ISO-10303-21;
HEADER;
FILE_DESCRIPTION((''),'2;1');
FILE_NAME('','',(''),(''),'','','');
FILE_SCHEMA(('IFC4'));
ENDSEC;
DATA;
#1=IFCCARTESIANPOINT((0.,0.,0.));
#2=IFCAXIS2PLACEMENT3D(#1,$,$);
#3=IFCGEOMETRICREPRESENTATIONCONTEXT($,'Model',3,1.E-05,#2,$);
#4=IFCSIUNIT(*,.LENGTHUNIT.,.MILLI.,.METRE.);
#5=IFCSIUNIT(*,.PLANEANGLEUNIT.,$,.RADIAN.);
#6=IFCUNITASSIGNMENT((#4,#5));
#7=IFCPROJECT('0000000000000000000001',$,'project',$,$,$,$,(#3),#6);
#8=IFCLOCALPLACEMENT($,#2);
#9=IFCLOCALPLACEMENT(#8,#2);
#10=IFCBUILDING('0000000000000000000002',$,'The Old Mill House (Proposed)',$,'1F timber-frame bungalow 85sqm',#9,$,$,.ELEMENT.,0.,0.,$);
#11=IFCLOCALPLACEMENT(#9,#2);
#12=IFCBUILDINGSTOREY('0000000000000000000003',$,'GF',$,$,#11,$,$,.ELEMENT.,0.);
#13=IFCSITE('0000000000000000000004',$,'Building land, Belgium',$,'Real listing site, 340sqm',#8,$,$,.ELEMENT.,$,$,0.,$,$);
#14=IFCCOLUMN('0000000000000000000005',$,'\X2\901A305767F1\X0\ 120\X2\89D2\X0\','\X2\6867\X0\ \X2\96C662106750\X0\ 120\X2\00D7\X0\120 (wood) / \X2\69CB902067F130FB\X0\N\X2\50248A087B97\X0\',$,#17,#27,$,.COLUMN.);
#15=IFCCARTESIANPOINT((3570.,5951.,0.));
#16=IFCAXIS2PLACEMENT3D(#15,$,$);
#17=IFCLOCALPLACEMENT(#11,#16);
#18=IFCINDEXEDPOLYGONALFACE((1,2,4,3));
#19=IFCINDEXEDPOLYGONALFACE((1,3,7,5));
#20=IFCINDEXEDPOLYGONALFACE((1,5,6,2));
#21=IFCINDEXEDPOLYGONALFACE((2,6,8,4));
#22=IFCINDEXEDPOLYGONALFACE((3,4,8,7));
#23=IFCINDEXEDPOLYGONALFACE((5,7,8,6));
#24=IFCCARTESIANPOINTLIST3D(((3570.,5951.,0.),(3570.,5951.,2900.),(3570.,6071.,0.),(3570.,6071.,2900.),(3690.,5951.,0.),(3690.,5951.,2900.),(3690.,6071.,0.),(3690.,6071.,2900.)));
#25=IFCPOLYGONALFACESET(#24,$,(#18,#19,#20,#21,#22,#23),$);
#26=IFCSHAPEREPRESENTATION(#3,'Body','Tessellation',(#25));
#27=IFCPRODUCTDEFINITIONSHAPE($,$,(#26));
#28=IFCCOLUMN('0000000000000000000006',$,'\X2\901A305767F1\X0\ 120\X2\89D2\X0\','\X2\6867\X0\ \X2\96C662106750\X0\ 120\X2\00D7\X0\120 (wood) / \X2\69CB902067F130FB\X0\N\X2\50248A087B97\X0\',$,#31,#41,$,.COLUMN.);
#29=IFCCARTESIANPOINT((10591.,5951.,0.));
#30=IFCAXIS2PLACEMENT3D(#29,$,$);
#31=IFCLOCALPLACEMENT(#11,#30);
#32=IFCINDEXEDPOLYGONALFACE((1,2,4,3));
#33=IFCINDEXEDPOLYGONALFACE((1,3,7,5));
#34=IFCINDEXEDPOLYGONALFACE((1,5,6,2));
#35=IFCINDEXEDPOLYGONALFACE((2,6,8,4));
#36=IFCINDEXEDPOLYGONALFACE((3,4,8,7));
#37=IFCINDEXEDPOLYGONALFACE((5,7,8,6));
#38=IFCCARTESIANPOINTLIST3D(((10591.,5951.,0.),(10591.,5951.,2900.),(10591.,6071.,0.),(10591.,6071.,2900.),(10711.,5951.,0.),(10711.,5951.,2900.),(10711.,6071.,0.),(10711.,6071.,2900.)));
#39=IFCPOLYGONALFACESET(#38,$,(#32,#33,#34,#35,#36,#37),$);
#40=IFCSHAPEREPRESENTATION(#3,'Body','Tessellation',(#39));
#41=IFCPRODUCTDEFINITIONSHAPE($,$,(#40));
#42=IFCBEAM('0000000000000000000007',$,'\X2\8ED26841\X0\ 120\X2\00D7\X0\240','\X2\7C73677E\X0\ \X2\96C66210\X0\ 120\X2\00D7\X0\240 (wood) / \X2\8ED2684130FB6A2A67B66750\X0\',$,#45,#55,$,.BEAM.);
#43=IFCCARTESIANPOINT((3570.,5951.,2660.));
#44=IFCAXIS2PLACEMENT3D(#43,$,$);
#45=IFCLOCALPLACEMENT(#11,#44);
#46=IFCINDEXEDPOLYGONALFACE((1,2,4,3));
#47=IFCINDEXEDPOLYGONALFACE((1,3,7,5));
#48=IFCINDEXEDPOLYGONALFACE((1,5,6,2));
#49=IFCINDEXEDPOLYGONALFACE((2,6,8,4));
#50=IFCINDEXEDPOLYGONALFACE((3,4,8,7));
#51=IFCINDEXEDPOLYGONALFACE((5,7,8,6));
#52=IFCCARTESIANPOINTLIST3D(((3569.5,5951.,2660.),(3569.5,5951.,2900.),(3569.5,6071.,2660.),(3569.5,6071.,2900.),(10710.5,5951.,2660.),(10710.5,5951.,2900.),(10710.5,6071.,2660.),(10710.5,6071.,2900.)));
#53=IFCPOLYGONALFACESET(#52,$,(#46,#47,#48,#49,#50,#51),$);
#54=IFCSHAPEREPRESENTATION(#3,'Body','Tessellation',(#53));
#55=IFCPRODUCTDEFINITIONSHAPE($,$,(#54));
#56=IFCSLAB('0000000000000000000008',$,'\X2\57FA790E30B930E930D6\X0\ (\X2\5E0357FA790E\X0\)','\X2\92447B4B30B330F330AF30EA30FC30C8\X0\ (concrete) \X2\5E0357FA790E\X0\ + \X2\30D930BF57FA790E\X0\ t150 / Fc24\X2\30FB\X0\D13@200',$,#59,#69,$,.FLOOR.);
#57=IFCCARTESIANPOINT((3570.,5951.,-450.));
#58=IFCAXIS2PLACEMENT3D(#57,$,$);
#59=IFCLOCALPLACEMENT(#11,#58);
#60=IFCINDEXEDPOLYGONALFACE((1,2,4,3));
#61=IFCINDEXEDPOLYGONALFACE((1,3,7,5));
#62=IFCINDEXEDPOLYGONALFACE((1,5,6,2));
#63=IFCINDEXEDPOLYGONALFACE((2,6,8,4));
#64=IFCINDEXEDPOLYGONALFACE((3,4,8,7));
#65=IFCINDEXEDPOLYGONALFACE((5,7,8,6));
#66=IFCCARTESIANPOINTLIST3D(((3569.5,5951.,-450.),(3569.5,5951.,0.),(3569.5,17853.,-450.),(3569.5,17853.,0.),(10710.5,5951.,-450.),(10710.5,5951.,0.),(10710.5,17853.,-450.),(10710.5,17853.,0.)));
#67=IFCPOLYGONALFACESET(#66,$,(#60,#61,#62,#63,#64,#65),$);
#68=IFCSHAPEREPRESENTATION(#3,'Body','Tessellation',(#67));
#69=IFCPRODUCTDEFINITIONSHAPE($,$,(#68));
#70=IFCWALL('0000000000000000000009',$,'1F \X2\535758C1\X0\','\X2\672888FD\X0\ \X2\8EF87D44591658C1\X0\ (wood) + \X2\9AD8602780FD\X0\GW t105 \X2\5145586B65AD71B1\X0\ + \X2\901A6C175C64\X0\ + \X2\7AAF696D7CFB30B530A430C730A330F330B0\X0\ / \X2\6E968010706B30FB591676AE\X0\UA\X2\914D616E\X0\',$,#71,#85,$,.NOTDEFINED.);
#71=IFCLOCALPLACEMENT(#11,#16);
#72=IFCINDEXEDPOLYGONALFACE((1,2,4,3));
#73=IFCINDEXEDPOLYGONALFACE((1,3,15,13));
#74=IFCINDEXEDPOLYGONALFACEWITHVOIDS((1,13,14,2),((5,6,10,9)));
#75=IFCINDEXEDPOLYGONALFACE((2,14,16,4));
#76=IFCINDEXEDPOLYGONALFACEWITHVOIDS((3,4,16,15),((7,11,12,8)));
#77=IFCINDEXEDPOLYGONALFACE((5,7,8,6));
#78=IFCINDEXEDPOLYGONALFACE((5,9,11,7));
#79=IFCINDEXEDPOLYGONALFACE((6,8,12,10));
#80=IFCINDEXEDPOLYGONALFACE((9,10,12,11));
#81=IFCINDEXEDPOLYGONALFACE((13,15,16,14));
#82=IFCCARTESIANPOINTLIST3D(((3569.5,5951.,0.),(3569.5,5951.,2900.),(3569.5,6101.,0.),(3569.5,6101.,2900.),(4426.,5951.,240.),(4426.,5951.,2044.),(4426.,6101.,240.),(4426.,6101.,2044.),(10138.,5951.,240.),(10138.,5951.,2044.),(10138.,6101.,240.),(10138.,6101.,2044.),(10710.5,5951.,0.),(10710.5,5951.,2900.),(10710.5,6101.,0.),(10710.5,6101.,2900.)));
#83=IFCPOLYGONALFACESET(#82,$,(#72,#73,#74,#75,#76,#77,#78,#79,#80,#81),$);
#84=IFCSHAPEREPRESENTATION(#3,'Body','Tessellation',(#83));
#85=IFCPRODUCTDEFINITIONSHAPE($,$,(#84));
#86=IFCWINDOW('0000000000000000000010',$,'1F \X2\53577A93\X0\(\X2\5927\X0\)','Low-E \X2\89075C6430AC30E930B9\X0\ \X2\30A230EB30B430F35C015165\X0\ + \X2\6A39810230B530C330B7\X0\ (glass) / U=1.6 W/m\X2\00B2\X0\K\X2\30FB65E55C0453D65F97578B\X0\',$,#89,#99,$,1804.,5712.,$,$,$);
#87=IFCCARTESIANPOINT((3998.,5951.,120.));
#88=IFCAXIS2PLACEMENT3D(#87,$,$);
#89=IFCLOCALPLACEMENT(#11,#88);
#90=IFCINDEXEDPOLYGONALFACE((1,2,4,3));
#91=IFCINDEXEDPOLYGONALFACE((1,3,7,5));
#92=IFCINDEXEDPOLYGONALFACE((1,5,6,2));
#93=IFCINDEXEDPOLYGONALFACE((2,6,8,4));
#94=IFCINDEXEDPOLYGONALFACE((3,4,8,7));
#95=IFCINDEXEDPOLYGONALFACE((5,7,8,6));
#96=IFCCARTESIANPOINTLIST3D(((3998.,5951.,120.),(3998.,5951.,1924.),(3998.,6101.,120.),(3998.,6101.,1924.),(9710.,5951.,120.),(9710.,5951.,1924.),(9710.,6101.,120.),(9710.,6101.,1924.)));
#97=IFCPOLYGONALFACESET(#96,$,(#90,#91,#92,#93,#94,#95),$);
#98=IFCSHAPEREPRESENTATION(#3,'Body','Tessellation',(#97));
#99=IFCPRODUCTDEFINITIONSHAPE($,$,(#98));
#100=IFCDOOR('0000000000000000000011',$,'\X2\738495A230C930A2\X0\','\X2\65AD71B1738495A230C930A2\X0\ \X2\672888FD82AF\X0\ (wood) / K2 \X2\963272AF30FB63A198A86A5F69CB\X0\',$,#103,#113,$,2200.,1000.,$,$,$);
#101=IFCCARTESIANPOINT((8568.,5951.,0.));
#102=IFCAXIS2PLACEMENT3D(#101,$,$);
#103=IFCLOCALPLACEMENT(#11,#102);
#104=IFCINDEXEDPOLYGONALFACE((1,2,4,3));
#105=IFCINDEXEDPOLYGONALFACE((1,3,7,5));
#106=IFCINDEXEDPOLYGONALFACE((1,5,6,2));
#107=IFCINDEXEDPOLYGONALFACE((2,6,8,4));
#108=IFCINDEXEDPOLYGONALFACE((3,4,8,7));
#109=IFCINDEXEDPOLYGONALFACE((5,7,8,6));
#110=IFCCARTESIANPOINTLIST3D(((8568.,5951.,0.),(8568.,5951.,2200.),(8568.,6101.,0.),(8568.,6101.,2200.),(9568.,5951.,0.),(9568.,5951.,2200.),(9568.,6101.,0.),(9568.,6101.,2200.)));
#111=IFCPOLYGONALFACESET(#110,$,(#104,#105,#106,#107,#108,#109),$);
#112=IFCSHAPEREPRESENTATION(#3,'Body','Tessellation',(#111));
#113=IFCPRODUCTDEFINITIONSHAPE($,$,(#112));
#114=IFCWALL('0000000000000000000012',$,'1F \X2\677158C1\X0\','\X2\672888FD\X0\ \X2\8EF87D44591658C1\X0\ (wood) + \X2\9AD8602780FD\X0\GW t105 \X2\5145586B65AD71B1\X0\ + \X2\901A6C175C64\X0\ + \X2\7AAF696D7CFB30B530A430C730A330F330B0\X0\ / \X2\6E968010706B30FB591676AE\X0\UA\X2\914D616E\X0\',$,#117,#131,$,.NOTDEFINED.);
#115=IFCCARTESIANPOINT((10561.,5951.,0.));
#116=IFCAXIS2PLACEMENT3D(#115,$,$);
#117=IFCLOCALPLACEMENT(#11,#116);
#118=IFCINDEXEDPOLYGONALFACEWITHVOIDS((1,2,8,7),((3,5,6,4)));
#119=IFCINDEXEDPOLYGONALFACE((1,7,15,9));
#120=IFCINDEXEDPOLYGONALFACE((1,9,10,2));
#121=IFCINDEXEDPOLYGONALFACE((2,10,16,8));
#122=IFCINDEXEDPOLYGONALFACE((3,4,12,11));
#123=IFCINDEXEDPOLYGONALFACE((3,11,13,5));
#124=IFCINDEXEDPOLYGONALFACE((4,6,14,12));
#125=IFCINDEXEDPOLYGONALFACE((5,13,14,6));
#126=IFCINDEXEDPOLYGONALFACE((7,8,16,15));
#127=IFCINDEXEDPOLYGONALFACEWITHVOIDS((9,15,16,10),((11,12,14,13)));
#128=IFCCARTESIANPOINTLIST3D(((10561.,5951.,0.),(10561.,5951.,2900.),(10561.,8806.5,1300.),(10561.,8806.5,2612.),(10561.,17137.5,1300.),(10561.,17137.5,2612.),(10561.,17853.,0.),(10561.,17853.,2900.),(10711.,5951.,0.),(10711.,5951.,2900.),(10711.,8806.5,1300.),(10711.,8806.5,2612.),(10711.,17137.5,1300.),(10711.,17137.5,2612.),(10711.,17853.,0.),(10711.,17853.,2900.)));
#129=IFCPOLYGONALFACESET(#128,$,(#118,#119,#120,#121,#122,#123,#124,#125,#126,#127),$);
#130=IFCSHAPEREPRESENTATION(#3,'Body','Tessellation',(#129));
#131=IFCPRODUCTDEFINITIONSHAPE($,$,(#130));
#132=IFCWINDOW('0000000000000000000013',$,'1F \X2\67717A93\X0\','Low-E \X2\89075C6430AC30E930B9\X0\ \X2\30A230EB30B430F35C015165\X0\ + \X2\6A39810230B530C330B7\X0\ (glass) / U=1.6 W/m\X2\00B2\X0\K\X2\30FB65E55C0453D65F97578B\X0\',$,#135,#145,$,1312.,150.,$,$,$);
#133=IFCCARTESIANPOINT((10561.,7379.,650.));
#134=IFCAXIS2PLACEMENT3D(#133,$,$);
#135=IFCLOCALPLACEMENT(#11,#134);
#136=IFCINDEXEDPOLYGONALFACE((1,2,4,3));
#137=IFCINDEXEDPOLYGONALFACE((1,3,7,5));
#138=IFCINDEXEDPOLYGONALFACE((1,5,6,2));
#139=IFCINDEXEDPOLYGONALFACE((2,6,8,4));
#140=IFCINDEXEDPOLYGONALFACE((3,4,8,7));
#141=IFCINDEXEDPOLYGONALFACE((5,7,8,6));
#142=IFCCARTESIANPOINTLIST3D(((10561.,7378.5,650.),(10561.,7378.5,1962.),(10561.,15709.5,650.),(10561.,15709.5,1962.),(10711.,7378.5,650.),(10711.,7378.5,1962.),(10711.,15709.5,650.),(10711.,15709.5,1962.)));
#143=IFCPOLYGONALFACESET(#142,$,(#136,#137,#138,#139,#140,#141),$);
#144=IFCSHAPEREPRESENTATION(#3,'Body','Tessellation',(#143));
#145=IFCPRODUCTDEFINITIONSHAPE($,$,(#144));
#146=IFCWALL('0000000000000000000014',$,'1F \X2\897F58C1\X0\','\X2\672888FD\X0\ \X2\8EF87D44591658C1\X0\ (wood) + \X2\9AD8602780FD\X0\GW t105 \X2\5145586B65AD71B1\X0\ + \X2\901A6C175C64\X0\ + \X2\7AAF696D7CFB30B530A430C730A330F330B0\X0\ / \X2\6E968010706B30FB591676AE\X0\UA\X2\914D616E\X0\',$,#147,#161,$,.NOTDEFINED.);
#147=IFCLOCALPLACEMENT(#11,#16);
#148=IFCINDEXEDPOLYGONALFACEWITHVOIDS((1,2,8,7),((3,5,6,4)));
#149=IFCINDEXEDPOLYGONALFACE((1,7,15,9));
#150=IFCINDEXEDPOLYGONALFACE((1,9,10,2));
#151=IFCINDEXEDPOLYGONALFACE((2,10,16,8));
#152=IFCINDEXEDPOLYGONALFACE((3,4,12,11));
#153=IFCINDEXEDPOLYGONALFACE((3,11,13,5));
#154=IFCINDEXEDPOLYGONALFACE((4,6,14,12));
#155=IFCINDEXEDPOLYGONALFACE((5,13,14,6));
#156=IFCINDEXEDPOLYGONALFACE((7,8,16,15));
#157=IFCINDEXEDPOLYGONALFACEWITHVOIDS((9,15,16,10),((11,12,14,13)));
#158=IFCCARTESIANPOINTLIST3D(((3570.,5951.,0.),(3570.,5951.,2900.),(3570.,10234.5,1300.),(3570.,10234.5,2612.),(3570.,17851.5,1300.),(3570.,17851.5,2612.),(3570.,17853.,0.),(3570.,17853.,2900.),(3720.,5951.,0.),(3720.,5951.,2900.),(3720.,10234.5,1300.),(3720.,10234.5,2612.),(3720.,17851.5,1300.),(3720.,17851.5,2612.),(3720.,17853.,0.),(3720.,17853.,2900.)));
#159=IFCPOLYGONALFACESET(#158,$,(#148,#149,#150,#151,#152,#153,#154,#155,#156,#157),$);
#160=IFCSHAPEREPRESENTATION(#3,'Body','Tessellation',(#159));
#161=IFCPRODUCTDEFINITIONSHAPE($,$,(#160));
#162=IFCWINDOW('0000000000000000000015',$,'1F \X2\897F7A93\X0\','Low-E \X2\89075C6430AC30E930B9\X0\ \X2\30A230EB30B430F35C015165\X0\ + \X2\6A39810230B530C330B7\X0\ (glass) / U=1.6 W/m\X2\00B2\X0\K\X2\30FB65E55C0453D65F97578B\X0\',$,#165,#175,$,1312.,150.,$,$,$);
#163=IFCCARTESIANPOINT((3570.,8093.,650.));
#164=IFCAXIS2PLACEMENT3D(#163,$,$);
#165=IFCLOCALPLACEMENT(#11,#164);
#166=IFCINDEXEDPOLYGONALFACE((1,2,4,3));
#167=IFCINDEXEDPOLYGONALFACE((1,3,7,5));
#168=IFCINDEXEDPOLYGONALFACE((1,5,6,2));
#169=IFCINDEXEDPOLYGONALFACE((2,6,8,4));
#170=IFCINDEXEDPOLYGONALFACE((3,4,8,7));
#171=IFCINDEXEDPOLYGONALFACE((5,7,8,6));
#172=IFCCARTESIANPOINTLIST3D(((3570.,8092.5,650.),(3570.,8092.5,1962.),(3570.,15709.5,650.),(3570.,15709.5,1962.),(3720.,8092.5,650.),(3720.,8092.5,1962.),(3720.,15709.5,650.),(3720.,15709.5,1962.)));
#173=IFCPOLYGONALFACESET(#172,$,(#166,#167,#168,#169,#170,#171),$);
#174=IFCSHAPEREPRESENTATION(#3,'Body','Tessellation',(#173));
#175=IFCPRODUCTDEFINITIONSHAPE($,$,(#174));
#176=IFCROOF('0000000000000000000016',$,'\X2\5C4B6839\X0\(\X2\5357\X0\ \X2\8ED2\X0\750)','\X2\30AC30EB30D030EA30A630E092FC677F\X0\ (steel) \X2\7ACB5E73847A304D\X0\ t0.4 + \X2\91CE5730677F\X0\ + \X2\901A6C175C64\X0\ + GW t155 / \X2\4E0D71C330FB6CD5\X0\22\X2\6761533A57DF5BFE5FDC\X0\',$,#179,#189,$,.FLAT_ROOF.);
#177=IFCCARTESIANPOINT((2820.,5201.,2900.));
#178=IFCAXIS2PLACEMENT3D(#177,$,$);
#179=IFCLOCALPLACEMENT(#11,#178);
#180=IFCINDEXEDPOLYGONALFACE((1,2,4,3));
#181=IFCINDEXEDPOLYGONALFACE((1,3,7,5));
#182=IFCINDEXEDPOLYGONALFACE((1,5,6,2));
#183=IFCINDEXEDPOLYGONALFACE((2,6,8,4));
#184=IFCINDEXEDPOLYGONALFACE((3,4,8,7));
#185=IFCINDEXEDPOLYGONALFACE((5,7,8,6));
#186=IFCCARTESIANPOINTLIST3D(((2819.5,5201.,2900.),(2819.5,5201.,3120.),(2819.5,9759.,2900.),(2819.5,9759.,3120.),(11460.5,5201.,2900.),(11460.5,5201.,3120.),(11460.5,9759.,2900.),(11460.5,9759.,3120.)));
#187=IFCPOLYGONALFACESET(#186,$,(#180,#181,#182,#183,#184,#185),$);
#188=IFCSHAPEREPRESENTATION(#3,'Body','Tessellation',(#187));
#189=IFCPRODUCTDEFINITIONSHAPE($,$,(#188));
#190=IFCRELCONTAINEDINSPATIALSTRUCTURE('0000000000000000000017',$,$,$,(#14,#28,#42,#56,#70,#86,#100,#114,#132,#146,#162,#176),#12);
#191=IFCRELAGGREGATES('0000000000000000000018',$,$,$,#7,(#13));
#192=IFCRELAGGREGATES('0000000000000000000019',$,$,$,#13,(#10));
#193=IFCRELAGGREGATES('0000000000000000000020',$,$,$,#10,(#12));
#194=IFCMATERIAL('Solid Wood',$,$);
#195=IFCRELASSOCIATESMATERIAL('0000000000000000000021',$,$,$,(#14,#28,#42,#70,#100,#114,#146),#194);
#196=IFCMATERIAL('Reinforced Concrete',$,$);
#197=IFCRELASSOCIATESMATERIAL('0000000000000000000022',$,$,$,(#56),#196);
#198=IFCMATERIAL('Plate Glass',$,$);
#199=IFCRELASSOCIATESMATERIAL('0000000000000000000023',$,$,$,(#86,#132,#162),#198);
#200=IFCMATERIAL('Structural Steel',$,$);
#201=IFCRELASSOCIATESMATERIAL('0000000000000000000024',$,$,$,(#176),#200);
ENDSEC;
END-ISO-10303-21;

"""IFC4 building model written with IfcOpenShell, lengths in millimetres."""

from ifc_helpers import new_model, si_unit, frame, frame_2d, origin, place, context, project, spatial, rectangle, extrude, material, element, fill, save


model = new_model("IFC4")

# Units and contexts
model_context = context("Model", 3, precision=1e-05, world=origin())
ifc_project = project(units=[si_unit("LENGTHUNIT", "METRE", prefix="MILLI"), si_unit("PLANEANGLEUNIT", "RADIAN")], contexts=[model_context])

# Site, building, storey
site_placement = place(None, origin())
site = spatial("IfcSite", under=ifc_project, at=site_placement, Name="Building land, Belgium", ObjectType="Real listing site, 340sqm", CompositionType="ELEMENT", RefElevation=0.0)
building_placement = place(site_placement, origin())
building = spatial("IfcBuilding", under=site, at=building_placement, Name="The Old Mill House (Proposed)", ObjectType="1F timber-frame bungalow 85sqm", CompositionType="ELEMENT", ElevationOfRefHeight=0.0, ElevationOfTerrain=0.0)
storey_placement = place(building_placement, origin())
storey = spatial("IfcBuildingStorey", under=building, at=storey_placement, Name="GF", CompositionType="ELEMENT", Elevation=0.0)

# Columns
ifc_material_1 = material(Name="Solid Wood")
column_1_placement = place(storey_placement, frame((3570.0, 5951.0, 0.0)))
element("IfcColumn", 1, at=column_1_placement, inside=storey, material=ifc_material_1, Name="通し柱 120角", Description="桧 集成材 120×120 (wood) / 構造柱・N値計算", PredefinedType="COLUMN", context=model_context, shape_type="SweptSolid", body=[
    extrude(rectangle(XDim=120.0, YDim=120.0, at=frame_2d((60.0, 60.0))), frame((3570.0, 5951.0, 0.0)), (0.0, 0.0, 1.0), 2900.0),
])
column_2_placement = place(storey_placement, frame((10591.0, 5951.0, 0.0)))
element("IfcColumn", 2, at=column_2_placement, inside=storey, material=ifc_material_1, Name="通し柱 120角", Description="桧 集成材 120×120 (wood) / 構造柱・N値計算", PredefinedType="COLUMN", context=model_context, shape_type="SweptSolid", body=[
    extrude(rectangle(XDim=120.0, YDim=120.0, at=frame_2d((60.0, 60.0))), frame((10591.0, 5951.0, 0.0)), (0.0, 0.0, 1.0), 2900.0),
])

# Beam
beam_1_placement = place(storey_placement, frame((3570.0, 5951.0, 2660.0)))
element("IfcBeam", 3, at=beam_1_placement, inside=storey, material=ifc_material_1, Name="軒桁 120×240", Description="米松 集成 120×240 (wood) / 軒桁・横架材", PredefinedType="BEAM", context=model_context, shape_type="SweptSolid", body=[
    extrude(rectangle(XDim=7141.0, YDim=120.0, at=frame_2d((3570.0, 60.0))), frame((3570.0, 5951.0, 2660.0)), (0.0, 0.0, 1.0), 240.0),
])

# Slab
ifc_material_2 = material(Name="Reinforced Concrete")
slab_1_placement = place(storey_placement, frame((3570.0, 5951.0, -450.0)))
element("IfcSlab", 4, at=slab_1_placement, inside=storey, material=ifc_material_2, Name="基礎スラブ (布基礎)", Description="鉄筋コンクリート (concrete) 布基礎 + ベタ基礎 t150 / Fc24・D13@200", PredefinedType="FLOOR", context=model_context, shape_type="SweptSolid", body=[
    extrude(rectangle(XDim=7141.0, YDim=11902.0, at=frame_2d((3570.0, 5951.0))), frame((3570.0, 5951.0, -450.0)), (0.0, 0.0, 1.0), 450.0),
])

# Wall, openings, window, door
wall_1_placement = place(storey_placement, frame((3570.0, 5951.0, 0.0)))
wall_1 = element("IfcWall", 5, at=wall_1_placement, inside=storey, material=ifc_material_1, Name="1F 南壁", Description="木製 軸組外壁 (wood) + 高性能GW t105 充填断熱 + 通気層 + 窯業系サイディング / 準耐火・外皮UA配慮", PredefinedType="NOTDEFINED", context=model_context, shape_type="SweptSolid", body=[
    extrude(rectangle(XDim=7141.0, YDim=150.0, at=frame_2d((3570.0, 75.0))), frame((3570.0, 5951.0, 0.0)), (0.0, 0.0, 1.0), 2900.0),
])
opening_1_placement = place(storey_placement, frame((3998.0, 5951.0, 120.0)))
opening_1 = element("IfcOpeningElement", 6, at=opening_1_placement, cuts=wall_1, PredefinedType="NOTDEFINED", context=model_context, shape_type="SweptSolid", body=[
    extrude(rectangle(XDim=5712.0, YDim=150.0, at=frame_2d((2856.0, 75.0))), frame((3998.0, 5951.0, 120.0)), (0.0, 0.0, 1.0), 1804.0),
])
opening_2_placement = place(storey_placement, frame((8568.0, 5951.0, 0.0)))
opening_2 = element("IfcOpeningElement", 7, at=opening_2_placement, cuts=wall_1, PredefinedType="NOTDEFINED", context=model_context, shape_type="SweptSolid", body=[
    extrude(rectangle(XDim=1000.0, YDim=150.0, at=frame_2d((500.0, 75.0))), frame((8568.0, 5951.0, 0.0)), (0.0, 0.0, 1.0), 2200.0),
])
ifc_material_3 = material(Name="Plate Glass")
window_1_placement = place(storey_placement, frame((3998.0, 5951.0, 120.0)))
window_1 = element("IfcWindow", 8, at=window_1_placement, inside=storey, material=ifc_material_3, Name="1F 南窓(大)", Description="Low-E 複層ガラス アルゴン封入 + 樹脂サッシ (glass) / U=1.6 W/m²K・日射取得型", OverallHeight=1804.0, OverallWidth=5712.0, context=model_context, shape_type="SweptSolid", body=[
    extrude(rectangle(XDim=5712.0, YDim=150.0, at=frame_2d((2856.0, 75.0))), frame((3998.0, 5951.0, 120.0)), (0.0, 0.0, 1.0), 1804.0),
])
fill(opening_1, window_1)
door_placement = place(storey_placement, frame((8568.0, 5951.0, 0.0)))
door = element("IfcDoor", 9, at=door_placement, inside=storey, material=ifc_material_1, Name="玄関ドア", Description="断熱玄関ドア 木製芯 (wood) / K2 防犯・採風機構", OverallHeight=2200.0, OverallWidth=1000.0, context=model_context, shape_type="SweptSolid", body=[
    extrude(rectangle(XDim=1000.0, YDim=150.0, at=frame_2d((500.0, 75.0))), frame((8568.0, 5951.0, 0.0)), (0.0, 0.0, 1.0), 2200.0),
])
fill(opening_2, door)

# Walls, openings, windows
wall_2_placement = place(storey_placement, frame((10561.0, 5951.0, 0.0)))
wall_2 = element("IfcWall", 10, at=wall_2_placement, inside=storey, material=ifc_material_1, Name="1F 東壁", Description="木製 軸組外壁 (wood) + 高性能GW t105 充填断熱 + 通気層 + 窯業系サイディング / 準耐火・外皮UA配慮", PredefinedType="NOTDEFINED", context=model_context, shape_type="SweptSolid", body=[
    extrude(rectangle(XDim=150.0, YDim=11902.0, at=frame_2d((75.0, 5951.0))), frame((10561.0, 5951.0, 0.0)), (0.0, 0.0, 1.0), 2900.0),
])
opening_3_placement = place(storey_placement, frame((10561.0, 7379.0, 650.0)))
opening_3 = element("IfcOpeningElement", 11, at=opening_3_placement, cuts=wall_2, PredefinedType="NOTDEFINED", context=model_context, shape_type="SweptSolid", body=[
    extrude(rectangle(XDim=150.0, YDim=8331.0, at=frame_2d((75.0, 4165.0))), frame((10561.0, 7379.0, 650.0)), (0.0, 0.0, 1.0), 1312.0),
])
window_2_placement = place(storey_placement, frame((10561.0, 7379.0, 650.0)))
window_2 = element("IfcWindow", 12, at=window_2_placement, inside=storey, material=ifc_material_3, Name="1F 東窓", Description="Low-E 複層ガラス アルゴン封入 + 樹脂サッシ (glass) / U=1.6 W/m²K・日射取得型", OverallHeight=1312.0, OverallWidth=150.0, context=model_context, shape_type="SweptSolid", body=[
    extrude(rectangle(XDim=150.0, YDim=8331.0, at=frame_2d((75.0, 4165.0))), frame((10561.0, 7379.0, 650.0)), (0.0, 0.0, 1.0), 1312.0),
])
fill(opening_3, window_2)
wall_3_placement = place(storey_placement, frame((3570.0, 5951.0, 0.0)))
wall_3 = element("IfcWall", 13, at=wall_3_placement, inside=storey, material=ifc_material_1, Name="1F 西壁", Description="木製 軸組外壁 (wood) + 高性能GW t105 充填断熱 + 通気層 + 窯業系サイディング / 準耐火・外皮UA配慮", PredefinedType="NOTDEFINED", context=model_context, shape_type="SweptSolid", body=[
    extrude(rectangle(XDim=150.0, YDim=11902.0, at=frame_2d((75.0, 5951.0))), frame((3570.0, 5951.0, 0.0)), (0.0, 0.0, 1.0), 2900.0),
])
opening_4_placement = place(storey_placement, frame((3570.0, 8093.0, 650.0)))
opening_4 = element("IfcOpeningElement", 14, at=opening_4_placement, cuts=wall_3, PredefinedType="NOTDEFINED", context=model_context, shape_type="SweptSolid", body=[
    extrude(rectangle(XDim=150.0, YDim=7617.0, at=frame_2d((75.0, 3808.0))), frame((3570.0, 8093.0, 650.0)), (0.0, 0.0, 1.0), 1312.0),
])
window_3_placement = place(storey_placement, frame((3570.0, 8093.0, 650.0)))
window_3 = element("IfcWindow", 15, at=window_3_placement, inside=storey, material=ifc_material_3, Name="1F 西窓", Description="Low-E 複層ガラス アルゴン封入 + 樹脂サッシ (glass) / U=1.6 W/m²K・日射取得型", OverallHeight=1312.0, OverallWidth=150.0, context=model_context, shape_type="SweptSolid", body=[
    extrude(rectangle(XDim=150.0, YDim=7617.0, at=frame_2d((75.0, 3808.0))), frame((3570.0, 8093.0, 650.0)), (0.0, 0.0, 1.0), 1312.0),
])
fill(opening_4, window_3)

# Roof
ifc_material_4 = material(Name="Structural Steel")
roof_placement = place(storey_placement, frame((2820.0, 5201.0, 2900.0)))
element("IfcRoof", 16, at=roof_placement, inside=storey, material=ifc_material_4, Name="屋根(南 軒750)", Description="ガルバリウム鋼板 (steel) 立平葺き t0.4 + 野地板 + 通気層 + GW t155 / 不燃・法22条区域対応", PredefinedType="FLAT_ROOF", context=model_context, shape_type="SweptSolid", body=[
    extrude(rectangle(XDim=8641.0, YDim=4558.0, at=frame_2d((4320.0, 2279.0))), frame((2820.0, 5201.0, 2900.0)), (0.0, 0.0, 1.0), 220.0),
])

save(model, "model.ifc")
